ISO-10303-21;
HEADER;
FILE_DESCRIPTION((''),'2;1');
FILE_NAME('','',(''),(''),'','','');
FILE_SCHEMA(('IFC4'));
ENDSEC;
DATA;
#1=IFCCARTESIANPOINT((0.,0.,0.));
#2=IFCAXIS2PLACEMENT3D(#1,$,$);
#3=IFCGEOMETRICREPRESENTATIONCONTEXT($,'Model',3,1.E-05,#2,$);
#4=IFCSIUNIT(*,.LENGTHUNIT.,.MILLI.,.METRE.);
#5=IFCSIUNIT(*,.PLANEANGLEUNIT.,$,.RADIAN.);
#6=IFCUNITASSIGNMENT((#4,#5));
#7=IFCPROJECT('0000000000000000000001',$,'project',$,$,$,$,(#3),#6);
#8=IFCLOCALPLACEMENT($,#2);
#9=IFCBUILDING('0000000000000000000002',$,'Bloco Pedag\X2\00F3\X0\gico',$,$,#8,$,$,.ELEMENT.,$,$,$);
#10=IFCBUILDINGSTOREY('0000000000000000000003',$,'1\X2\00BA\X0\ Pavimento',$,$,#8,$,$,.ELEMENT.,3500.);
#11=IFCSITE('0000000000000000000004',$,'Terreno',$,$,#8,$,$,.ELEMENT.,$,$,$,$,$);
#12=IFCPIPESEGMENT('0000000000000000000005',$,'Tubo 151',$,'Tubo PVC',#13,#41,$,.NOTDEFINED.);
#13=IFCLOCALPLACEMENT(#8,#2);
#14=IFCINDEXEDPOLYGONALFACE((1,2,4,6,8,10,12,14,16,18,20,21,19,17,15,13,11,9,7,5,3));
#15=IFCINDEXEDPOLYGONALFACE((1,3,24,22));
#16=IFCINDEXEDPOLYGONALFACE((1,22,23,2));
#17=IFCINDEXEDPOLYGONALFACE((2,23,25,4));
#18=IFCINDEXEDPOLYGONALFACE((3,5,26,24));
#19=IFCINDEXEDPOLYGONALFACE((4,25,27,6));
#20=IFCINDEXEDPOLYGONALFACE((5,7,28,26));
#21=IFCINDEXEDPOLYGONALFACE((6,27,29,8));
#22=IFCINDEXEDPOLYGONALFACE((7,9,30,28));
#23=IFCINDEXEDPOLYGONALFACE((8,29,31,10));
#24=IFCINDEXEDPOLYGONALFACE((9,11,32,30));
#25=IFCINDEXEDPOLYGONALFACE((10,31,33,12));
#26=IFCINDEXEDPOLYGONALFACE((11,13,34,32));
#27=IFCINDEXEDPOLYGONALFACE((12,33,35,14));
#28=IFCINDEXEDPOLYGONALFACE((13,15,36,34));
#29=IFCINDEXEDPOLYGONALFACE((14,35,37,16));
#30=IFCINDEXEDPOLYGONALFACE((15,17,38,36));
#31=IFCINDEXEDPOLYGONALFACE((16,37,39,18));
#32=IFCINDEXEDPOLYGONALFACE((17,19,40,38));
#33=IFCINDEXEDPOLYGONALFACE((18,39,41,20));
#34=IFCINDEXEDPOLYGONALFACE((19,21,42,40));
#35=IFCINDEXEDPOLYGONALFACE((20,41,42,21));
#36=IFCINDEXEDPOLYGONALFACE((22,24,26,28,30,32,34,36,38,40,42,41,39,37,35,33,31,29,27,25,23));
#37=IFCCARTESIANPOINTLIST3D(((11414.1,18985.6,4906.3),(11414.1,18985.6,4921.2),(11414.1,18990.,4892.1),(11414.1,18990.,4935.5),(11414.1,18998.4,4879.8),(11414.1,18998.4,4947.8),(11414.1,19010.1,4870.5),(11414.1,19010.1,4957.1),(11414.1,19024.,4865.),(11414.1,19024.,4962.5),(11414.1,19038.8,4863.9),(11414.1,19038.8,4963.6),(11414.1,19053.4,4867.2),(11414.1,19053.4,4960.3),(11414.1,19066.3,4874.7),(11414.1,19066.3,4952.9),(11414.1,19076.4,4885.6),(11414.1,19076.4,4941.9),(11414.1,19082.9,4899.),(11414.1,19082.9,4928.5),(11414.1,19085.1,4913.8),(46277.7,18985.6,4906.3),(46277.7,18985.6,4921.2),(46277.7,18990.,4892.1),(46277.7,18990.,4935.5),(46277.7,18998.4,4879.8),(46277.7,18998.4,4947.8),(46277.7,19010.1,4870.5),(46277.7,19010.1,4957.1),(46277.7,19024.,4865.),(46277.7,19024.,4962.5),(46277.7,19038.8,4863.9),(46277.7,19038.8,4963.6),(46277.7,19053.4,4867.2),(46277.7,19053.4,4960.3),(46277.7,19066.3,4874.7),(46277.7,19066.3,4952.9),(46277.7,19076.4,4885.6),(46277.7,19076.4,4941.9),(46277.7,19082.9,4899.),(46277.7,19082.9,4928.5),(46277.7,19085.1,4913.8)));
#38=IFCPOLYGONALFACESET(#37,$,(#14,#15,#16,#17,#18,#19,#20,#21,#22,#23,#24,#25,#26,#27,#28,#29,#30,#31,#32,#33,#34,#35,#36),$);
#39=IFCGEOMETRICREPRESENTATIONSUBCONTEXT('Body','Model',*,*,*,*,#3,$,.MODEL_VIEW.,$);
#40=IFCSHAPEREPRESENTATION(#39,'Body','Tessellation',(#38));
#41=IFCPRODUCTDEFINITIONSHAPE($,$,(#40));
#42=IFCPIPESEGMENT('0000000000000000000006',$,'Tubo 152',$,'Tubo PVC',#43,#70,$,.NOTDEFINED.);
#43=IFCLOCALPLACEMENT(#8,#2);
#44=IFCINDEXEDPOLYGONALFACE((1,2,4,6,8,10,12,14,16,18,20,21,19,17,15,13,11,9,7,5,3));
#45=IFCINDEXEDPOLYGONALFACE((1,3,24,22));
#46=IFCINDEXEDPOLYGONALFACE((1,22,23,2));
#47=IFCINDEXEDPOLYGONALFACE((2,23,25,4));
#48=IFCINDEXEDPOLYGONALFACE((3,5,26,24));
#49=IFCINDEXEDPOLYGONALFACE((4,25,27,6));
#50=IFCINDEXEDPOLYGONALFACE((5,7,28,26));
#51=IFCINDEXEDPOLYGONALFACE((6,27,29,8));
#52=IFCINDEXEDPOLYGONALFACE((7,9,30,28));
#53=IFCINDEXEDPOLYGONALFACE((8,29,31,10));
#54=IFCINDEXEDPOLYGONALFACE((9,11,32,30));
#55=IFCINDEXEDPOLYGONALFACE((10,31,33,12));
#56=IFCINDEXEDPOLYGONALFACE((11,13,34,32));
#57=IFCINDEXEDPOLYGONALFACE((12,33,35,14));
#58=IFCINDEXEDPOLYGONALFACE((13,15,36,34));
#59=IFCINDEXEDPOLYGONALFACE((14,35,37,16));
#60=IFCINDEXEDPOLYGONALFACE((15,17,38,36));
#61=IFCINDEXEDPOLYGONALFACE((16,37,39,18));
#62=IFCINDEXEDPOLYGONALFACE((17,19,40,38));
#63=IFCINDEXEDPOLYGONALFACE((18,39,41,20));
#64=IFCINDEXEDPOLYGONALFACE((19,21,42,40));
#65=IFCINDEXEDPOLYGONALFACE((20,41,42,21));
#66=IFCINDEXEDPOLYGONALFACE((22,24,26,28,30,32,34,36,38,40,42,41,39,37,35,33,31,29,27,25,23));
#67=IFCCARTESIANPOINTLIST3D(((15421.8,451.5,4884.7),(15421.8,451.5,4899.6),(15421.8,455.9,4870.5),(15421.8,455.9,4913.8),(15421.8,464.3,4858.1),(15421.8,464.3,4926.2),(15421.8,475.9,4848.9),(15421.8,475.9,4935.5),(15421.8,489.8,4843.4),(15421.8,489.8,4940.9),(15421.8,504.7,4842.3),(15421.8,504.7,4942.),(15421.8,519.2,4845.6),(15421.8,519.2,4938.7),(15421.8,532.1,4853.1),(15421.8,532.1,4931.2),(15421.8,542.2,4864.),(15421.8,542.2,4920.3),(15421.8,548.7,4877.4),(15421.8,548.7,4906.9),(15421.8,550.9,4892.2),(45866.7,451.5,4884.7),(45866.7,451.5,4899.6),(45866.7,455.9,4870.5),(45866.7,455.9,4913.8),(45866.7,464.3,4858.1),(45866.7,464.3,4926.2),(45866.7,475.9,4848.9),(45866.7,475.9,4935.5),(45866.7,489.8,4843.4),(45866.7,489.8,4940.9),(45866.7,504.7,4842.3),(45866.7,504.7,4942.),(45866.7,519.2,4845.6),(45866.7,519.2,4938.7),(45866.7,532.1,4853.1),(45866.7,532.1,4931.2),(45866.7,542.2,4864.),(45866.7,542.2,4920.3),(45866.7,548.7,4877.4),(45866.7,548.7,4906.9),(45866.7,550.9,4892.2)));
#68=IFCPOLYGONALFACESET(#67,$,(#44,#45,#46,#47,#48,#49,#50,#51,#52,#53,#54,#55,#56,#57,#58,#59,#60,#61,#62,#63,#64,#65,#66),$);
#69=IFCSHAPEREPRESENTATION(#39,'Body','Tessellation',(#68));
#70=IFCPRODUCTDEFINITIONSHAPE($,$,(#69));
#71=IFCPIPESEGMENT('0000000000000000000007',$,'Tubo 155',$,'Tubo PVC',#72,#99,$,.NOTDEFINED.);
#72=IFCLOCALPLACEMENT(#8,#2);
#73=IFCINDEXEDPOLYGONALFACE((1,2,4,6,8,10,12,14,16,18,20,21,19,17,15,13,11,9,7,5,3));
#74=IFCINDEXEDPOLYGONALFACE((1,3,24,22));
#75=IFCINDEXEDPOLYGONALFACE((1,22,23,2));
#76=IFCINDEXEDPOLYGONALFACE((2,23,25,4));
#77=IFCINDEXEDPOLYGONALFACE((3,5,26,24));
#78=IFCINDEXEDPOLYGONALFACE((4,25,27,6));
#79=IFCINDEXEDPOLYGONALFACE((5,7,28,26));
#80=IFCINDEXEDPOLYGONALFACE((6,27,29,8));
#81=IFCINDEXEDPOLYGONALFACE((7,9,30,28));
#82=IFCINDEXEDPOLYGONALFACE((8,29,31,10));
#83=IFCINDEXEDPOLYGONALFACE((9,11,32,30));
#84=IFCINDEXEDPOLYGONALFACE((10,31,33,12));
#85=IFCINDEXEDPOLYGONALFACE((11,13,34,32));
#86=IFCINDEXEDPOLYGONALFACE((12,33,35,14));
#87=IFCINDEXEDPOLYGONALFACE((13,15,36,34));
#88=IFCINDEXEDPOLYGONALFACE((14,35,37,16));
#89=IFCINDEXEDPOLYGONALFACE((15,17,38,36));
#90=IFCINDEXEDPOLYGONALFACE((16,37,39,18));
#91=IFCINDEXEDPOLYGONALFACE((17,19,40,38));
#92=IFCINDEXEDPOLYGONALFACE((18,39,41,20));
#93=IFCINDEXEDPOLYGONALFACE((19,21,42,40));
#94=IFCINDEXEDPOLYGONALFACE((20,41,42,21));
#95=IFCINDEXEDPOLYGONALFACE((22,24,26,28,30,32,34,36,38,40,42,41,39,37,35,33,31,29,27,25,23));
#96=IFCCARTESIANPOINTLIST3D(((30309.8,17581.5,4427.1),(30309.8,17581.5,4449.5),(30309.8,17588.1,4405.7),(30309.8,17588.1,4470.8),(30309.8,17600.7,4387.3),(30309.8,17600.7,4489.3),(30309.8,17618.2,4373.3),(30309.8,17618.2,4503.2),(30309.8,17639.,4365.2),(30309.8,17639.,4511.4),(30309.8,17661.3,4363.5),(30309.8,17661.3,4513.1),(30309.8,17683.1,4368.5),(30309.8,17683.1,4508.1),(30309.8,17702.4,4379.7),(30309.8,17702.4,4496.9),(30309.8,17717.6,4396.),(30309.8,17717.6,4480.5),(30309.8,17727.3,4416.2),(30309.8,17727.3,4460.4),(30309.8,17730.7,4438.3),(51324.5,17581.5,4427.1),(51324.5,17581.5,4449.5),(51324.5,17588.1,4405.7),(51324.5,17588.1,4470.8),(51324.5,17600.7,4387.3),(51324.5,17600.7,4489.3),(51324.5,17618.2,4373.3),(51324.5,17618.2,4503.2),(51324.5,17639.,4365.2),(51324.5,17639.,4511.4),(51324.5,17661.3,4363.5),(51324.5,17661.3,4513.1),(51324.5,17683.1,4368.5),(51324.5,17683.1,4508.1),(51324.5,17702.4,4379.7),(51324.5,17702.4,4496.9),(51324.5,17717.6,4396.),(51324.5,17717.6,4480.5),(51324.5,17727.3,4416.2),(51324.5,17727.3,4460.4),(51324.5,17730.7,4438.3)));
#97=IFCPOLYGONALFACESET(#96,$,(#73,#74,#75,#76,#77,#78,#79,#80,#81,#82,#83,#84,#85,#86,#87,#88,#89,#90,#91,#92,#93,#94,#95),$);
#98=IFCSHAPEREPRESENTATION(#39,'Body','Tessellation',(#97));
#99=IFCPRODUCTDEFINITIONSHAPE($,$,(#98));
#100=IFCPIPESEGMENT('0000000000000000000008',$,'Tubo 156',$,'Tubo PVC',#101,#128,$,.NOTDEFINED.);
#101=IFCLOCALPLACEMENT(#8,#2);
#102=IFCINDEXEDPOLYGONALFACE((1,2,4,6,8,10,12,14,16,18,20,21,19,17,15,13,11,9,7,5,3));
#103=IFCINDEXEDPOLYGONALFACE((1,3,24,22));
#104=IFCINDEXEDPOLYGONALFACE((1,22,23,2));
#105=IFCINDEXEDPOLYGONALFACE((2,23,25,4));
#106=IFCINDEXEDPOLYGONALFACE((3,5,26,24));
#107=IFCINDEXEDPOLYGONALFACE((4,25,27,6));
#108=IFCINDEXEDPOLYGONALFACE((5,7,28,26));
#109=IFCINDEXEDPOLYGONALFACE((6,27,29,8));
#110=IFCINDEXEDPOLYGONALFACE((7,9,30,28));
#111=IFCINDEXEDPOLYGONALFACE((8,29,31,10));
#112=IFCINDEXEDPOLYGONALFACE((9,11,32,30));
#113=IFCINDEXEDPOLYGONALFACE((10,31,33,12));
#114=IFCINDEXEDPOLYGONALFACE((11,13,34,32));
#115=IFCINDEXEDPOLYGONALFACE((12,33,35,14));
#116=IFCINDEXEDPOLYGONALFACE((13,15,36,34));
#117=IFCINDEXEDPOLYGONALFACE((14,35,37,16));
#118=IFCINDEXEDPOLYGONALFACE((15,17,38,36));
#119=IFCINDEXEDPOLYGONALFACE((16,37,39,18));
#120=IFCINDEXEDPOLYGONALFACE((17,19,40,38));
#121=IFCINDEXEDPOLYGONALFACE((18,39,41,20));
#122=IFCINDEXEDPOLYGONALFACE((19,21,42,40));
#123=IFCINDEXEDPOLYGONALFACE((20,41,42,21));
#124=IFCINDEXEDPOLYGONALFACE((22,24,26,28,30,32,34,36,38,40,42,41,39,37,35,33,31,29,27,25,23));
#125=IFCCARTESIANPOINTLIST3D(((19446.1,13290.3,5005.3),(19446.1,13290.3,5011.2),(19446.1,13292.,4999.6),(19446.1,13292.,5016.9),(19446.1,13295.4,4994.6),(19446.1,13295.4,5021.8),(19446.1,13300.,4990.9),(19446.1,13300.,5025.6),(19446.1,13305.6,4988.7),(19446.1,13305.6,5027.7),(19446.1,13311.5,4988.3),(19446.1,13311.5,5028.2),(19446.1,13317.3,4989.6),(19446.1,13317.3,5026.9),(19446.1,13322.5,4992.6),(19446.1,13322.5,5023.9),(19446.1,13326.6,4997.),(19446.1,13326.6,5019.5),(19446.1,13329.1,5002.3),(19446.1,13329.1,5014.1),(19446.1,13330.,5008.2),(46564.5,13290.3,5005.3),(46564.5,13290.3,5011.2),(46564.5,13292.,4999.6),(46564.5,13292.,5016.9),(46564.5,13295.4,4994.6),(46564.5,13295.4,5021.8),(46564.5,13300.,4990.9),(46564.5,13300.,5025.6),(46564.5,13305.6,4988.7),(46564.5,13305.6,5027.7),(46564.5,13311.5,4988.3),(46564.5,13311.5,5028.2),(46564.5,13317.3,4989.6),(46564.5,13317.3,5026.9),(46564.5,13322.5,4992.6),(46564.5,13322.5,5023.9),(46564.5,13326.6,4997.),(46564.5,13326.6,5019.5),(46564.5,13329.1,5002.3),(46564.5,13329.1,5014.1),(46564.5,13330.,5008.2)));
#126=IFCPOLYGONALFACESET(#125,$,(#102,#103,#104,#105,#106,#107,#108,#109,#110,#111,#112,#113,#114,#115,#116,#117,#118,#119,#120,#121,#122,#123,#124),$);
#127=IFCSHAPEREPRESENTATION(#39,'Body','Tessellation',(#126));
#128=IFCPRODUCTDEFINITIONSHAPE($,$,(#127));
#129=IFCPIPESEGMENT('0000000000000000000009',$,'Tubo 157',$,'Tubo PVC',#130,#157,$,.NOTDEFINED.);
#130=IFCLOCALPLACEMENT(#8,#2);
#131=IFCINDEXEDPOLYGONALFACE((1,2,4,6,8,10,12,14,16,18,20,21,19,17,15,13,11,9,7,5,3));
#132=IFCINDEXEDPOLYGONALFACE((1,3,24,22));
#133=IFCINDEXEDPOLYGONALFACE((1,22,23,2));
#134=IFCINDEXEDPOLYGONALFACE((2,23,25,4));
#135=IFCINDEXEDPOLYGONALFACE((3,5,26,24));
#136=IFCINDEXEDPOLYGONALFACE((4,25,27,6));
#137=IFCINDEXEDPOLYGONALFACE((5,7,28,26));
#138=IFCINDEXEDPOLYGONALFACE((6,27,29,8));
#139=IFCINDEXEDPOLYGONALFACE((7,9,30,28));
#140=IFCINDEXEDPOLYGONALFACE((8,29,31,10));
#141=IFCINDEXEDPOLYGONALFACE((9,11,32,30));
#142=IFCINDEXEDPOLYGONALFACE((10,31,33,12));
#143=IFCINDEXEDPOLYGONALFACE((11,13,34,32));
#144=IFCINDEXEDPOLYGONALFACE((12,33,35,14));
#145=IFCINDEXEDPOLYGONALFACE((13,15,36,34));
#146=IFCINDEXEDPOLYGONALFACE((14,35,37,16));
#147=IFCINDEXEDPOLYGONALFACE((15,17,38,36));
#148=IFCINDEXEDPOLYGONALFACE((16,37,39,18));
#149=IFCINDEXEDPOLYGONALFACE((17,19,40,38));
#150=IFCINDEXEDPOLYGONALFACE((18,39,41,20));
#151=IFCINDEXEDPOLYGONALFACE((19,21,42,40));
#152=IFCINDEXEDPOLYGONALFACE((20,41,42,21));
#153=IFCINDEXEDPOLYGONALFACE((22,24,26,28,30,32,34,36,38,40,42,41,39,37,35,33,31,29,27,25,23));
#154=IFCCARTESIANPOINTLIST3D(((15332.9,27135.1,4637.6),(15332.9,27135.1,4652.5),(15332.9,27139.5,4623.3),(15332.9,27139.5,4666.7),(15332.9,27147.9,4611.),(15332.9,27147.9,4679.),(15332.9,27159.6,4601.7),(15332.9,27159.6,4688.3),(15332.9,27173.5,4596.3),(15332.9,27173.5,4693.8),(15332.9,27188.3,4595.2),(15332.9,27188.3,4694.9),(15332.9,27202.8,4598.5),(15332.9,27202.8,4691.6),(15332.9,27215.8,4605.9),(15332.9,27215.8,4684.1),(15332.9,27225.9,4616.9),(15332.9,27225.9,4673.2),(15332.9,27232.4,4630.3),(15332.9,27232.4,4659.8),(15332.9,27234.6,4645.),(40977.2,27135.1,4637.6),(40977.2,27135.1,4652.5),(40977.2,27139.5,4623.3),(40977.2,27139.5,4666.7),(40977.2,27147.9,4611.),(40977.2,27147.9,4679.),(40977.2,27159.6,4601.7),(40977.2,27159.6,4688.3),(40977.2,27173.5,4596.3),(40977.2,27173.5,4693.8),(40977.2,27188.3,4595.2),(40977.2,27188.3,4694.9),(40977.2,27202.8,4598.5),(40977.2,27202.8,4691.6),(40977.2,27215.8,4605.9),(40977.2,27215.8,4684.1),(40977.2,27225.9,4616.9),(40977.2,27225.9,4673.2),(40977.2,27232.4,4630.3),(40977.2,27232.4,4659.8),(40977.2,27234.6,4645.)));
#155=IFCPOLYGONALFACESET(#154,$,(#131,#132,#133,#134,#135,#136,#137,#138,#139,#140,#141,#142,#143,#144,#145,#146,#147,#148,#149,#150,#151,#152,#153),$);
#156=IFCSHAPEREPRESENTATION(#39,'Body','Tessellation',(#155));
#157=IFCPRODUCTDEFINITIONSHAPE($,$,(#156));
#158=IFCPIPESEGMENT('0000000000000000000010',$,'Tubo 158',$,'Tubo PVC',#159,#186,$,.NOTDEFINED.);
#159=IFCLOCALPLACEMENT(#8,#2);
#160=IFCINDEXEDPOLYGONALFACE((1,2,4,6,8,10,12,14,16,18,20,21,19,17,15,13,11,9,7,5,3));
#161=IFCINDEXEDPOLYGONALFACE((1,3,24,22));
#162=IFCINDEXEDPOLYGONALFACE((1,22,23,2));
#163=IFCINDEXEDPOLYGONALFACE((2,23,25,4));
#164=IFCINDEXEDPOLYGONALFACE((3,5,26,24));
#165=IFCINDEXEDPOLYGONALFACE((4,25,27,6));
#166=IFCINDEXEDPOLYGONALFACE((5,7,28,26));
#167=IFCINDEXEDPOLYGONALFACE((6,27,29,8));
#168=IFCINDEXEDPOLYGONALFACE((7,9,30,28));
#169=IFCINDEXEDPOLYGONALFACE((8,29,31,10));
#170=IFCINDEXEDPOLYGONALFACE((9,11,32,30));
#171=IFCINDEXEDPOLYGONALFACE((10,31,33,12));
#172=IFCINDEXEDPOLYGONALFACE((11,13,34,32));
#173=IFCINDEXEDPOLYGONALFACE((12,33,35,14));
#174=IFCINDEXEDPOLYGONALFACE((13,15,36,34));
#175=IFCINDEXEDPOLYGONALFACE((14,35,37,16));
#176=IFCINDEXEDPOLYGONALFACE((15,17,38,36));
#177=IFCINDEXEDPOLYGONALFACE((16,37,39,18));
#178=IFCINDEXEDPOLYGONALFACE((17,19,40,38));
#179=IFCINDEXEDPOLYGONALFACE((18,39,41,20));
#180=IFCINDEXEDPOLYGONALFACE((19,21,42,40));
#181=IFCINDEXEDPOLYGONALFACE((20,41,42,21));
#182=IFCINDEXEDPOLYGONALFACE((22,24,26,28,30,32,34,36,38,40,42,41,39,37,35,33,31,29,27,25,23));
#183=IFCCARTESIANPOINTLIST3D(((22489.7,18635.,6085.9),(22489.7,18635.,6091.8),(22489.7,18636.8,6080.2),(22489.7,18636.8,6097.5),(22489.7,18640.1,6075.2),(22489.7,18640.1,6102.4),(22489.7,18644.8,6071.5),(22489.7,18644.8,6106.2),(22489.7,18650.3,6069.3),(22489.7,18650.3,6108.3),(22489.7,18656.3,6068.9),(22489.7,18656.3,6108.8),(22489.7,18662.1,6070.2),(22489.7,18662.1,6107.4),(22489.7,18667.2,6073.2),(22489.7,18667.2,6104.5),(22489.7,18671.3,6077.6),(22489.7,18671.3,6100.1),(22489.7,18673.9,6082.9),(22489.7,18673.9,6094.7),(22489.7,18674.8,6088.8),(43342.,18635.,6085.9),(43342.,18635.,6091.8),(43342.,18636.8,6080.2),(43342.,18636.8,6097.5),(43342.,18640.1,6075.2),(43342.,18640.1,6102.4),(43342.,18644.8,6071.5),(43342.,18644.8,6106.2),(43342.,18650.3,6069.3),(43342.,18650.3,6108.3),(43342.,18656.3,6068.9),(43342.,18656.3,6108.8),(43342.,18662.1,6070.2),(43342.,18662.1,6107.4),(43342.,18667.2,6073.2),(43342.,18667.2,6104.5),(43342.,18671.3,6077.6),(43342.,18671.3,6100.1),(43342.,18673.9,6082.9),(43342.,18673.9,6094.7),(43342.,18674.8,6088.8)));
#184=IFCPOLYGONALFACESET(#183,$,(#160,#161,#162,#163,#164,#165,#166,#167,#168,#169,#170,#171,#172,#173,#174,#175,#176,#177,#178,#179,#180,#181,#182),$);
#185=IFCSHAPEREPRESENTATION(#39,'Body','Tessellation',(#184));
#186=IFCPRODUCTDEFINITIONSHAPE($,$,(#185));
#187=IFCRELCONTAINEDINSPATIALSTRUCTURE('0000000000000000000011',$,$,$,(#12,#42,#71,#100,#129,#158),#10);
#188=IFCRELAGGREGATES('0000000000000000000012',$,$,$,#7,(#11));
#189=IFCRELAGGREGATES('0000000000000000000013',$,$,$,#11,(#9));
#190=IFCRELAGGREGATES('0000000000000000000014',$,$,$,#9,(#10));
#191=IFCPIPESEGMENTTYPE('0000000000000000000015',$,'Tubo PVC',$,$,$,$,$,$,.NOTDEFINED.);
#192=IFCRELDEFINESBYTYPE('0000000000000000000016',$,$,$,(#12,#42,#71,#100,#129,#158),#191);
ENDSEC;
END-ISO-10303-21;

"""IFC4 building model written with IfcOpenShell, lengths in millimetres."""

from ifc_helpers import new_model, si_unit, frame, origin, origin_2d, place, context, subcontext, project, spatial, circle, extrude, type_object, element, save


model = new_model("IFC4")

# Units and contexts
model_context = context("Model", 3, precision=1e-05, world=origin())
body_context = subcontext(model_context, "Body", "Model", "MODEL_VIEW")
ifc_project = project(units=[si_unit("LENGTHUNIT", "METRE", prefix="MILLI"), si_unit("PLANEANGLEUNIT", "RADIAN")], contexts=[model_context])

# Site, building, storey
placement = place(None, origin())
site = spatial("IfcSite", under=ifc_project, at=placement, Name="Terreno", CompositionType="ELEMENT")
building = spatial("IfcBuilding", under=site, at=placement, Name="Bloco Pedagógico", CompositionType="ELEMENT")
storey = spatial("IfcBuildingStorey", under=building, at=placement, Name="1º Pavimento", CompositionType="ELEMENT", Elevation=3500.0)

# Pipe segments
pipe_segment_type = type_object("IfcPipeSegmentType", Name="Tubo PVC", PredefinedType="NOTDEFINED")
pipe_segment_1_placement = place(None, frame((11414.1, 19035.1, 4913.8), z_axis=(1.0, 0.0, 0.0), x_axis=(0.0, 1.0, 0.0)))
element("IfcPipeSegment", 1, at=pipe_segment_1_placement, inside=storey, type_object=pipe_segment_type, Name="Tubo 151", ObjectType="Tubo PVC", PredefinedType="NOTDEFINED", context=body_context, shape_type="SweptSolid", body=[
    extrude(circle(Radius=50.0, at=origin_2d()), None, (0.0, 0.0, 1.0), 34863.6),
])
pipe_segment_2_placement = place(None, frame((15421.8, 500.9, 4892.2), z_axis=(1.0, 0.0, 0.0), x_axis=(0.0, 1.0, 0.0)))
element("IfcPipeSegment", 2, at=pipe_segment_2_placement, inside=storey, type_object=pipe_segment_type, Name="Tubo 152", ObjectType="Tubo PVC", PredefinedType="NOTDEFINED", context=body_context, shape_type="SweptSolid", body=[
    extrude(circle(Radius=50.0, at=origin_2d()), None, (0.0, 0.0, 1.0), 30444.9),
])
pipe_segment_3_placement = place(None, frame((30309.8, 17655.7, 4438.3), z_axis=(1.0, 0.0, 0.0), x_axis=(0.0, 1.0, 0.0)))
element("IfcPipeSegment", 3, at=pipe_segment_3_placement, inside=storey, type_object=pipe_segment_type, Name="Tubo 155", ObjectType="Tubo PVC", PredefinedType="NOTDEFINED", context=body_context, shape_type="SweptSolid", body=[
    extrude(circle(Radius=75.0, at=origin_2d()), None, (0.0, 0.0, 1.0), 21014.6),
])
pipe_segment_4_placement = place(None, frame((19446.1, 13310.0, 5008.2), z_axis=(1.0, 0.0, 0.0), x_axis=(0.0, 1.0, 0.0)))
element("IfcPipeSegment", 4, at=pipe_segment_4_placement, inside=storey, type_object=pipe_segment_type, Name="Tubo 156", ObjectType="Tubo PVC", PredefinedType="NOTDEFINED", context=body_context, shape_type="SweptSolid", body=[
    extrude(circle(Radius=20.0, at=origin_2d()), None, (0.0, 0.0, 1.0), 27118.3),
])
pipe_segment_5_placement = place(None, frame((15332.9, 27184.6, 4645.0), z_axis=(1.0, 0.0, 0.0), x_axis=(0.0, 1.0, 0.0)))
element("IfcPipeSegment", 5, at=pipe_segment_5_placement, inside=storey, type_object=pipe_segment_type, Name="Tubo 157", ObjectType="Tubo PVC", PredefinedType="NOTDEFINED", context=body_context, shape_type="SweptSolid", body=[
    extrude(circle(Radius=50.0, at=origin_2d()), None, (0.0, 0.0, 1.0), 25644.3),
])
pipe_segment_6_placement = place(None, frame((22489.7, 18654.8, 6088.8), z_axis=(1.0, 0.0, 0.0), x_axis=(0.0, 1.0, 0.0)))
element("IfcPipeSegment", 6, at=pipe_segment_6_placement, inside=storey, type_object=pipe_segment_type, Name="Tubo 158", ObjectType="Tubo PVC", PredefinedType="NOTDEFINED", context=body_context, shape_type="SweptSolid", body=[
    extrude(circle(Radius=20.0, at=origin_2d()), None, (0.0, 0.0, 1.0), 20852.4),
])

save(model, "model.ifc")
